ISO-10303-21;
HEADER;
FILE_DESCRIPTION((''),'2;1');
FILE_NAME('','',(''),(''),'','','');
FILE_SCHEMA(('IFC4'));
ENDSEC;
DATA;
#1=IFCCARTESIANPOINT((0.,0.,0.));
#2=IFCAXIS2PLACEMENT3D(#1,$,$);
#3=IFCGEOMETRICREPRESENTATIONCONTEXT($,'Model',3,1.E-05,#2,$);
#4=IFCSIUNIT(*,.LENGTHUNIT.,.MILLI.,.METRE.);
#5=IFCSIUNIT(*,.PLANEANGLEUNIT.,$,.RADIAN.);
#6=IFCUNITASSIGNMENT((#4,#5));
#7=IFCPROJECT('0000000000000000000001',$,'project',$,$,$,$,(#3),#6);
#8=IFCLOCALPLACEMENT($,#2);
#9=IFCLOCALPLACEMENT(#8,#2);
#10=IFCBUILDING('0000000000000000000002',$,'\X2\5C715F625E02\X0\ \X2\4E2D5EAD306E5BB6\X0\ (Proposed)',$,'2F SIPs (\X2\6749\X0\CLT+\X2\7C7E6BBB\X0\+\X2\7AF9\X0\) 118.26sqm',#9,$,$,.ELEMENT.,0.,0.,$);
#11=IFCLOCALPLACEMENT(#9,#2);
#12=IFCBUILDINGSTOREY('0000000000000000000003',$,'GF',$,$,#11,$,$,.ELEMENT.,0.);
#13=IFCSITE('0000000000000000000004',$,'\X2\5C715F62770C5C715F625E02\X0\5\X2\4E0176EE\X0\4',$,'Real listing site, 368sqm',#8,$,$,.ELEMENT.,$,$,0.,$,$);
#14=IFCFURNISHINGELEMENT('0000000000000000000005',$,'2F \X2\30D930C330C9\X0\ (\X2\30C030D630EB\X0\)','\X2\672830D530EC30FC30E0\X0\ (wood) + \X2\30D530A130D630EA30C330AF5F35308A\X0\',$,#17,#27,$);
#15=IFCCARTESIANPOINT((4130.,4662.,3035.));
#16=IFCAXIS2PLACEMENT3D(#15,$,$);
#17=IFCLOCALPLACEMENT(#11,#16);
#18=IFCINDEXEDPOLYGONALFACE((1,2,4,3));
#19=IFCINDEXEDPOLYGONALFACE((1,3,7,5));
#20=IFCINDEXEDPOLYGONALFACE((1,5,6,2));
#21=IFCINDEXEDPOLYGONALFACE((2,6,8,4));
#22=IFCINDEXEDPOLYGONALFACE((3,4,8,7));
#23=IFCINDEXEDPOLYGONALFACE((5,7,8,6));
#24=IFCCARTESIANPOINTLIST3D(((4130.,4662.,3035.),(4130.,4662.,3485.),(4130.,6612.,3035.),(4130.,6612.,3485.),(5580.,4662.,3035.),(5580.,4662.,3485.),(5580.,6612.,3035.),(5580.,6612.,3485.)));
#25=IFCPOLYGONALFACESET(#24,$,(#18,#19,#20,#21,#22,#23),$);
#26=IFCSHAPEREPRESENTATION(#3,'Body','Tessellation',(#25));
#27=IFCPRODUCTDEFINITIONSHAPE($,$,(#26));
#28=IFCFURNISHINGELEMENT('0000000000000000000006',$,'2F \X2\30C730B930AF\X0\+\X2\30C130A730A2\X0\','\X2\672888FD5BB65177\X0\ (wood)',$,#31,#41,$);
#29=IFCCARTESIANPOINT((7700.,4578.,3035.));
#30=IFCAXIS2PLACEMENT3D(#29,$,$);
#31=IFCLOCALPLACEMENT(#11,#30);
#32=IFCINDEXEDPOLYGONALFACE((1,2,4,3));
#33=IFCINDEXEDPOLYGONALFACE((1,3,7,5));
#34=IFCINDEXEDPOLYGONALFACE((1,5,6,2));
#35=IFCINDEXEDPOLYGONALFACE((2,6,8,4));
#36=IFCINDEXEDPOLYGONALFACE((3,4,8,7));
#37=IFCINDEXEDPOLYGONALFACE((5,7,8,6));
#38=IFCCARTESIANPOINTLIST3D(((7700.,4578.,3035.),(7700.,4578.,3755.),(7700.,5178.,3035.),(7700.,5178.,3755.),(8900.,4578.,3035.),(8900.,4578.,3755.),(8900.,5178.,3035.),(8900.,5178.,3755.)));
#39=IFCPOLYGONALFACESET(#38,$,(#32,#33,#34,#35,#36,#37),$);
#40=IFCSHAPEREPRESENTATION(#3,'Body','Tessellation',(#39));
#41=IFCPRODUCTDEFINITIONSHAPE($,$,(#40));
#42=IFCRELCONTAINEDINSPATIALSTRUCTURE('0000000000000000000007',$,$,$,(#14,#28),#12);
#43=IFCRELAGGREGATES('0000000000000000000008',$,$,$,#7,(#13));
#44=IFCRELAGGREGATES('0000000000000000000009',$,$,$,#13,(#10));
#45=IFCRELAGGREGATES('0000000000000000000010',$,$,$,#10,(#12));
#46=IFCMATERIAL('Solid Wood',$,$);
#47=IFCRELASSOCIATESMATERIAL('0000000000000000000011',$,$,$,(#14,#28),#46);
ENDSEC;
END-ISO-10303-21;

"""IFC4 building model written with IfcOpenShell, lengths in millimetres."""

from ifc_helpers import new_model, si_unit, frame, frame_2d, origin, place, context, project, spatial, rectangle, extrude, material, element, save


model = new_model("IFC4")

# Units and contexts
model_context = context("Model", 3, precision=1e-05, world=origin())
ifc_project = project(units=[si_unit("LENGTHUNIT", "METRE", prefix="MILLI"), si_unit("PLANEANGLEUNIT", "RADIAN")], contexts=[model_context])

# Site, building, storey
site_placement = place(None, origin())
site = spatial("IfcSite", under=ifc_project, at=site_placement, Name="山形県山形市5丁目4", ObjectType="Real listing site, 368sqm", CompositionType="ELEMENT", RefElevation=0.0)
building_placement = place(site_placement, origin())
building = spatial("IfcBuilding", under=site, at=building_placement, Name="山形市 中庭の家 (Proposed)", ObjectType="2F SIPs (杉CLT+籾殻+竹) 118.26sqm", CompositionType="ELEMENT", ElevationOfRefHeight=0.0, ElevationOfTerrain=0.0)
storey_placement = place(building_placement, origin())
storey = spatial("IfcBuildingStorey", under=building, at=storey_placement, Name="GF", CompositionType="ELEMENT", Elevation=0.0)

# Shared definitions
ifc_material_1 = material(Name="Solid Wood")

# Furnishing elements
furnishing_1_placement = place(storey_placement, frame((4130.0, 4662.0, 3035.0)))
element("IfcFurnishingElement", 1, at=furnishing_1_placement, inside=storey, material=ifc_material_1, Name="2F ベッド (ダブル)", Description="木フレーム (wood) + ファブリック張り", context=model_context, shape_type="SweptSolid", body=[
    extrude(rectangle(XDim=1450.0, YDim=1950.0, at=frame_2d((725.0, 975.0))), frame((4130.0, 4662.0, 3035.0)), (0.0, 0.0, 1.0), 450.0),
])
furnishing_2_placement = place(storey_placement, frame((7700.0, 4578.0, 3035.0)))
element("IfcFurnishingElement", 2, at=furnishing_2_placement, inside=storey, material=ifc_material_1, Name="2F デスク+チェア", Description="木製家具 (wood)", context=model_context, shape_type="SweptSolid", body=[
    extrude(rectangle(XDim=1200.0, YDim=600.0, at=frame_2d((600.0, 300.0))), frame((7700.0, 4578.0, 3035.0)), (0.0, 0.0, 1.0), 720.0),
])

save(model, "model.ifc")
